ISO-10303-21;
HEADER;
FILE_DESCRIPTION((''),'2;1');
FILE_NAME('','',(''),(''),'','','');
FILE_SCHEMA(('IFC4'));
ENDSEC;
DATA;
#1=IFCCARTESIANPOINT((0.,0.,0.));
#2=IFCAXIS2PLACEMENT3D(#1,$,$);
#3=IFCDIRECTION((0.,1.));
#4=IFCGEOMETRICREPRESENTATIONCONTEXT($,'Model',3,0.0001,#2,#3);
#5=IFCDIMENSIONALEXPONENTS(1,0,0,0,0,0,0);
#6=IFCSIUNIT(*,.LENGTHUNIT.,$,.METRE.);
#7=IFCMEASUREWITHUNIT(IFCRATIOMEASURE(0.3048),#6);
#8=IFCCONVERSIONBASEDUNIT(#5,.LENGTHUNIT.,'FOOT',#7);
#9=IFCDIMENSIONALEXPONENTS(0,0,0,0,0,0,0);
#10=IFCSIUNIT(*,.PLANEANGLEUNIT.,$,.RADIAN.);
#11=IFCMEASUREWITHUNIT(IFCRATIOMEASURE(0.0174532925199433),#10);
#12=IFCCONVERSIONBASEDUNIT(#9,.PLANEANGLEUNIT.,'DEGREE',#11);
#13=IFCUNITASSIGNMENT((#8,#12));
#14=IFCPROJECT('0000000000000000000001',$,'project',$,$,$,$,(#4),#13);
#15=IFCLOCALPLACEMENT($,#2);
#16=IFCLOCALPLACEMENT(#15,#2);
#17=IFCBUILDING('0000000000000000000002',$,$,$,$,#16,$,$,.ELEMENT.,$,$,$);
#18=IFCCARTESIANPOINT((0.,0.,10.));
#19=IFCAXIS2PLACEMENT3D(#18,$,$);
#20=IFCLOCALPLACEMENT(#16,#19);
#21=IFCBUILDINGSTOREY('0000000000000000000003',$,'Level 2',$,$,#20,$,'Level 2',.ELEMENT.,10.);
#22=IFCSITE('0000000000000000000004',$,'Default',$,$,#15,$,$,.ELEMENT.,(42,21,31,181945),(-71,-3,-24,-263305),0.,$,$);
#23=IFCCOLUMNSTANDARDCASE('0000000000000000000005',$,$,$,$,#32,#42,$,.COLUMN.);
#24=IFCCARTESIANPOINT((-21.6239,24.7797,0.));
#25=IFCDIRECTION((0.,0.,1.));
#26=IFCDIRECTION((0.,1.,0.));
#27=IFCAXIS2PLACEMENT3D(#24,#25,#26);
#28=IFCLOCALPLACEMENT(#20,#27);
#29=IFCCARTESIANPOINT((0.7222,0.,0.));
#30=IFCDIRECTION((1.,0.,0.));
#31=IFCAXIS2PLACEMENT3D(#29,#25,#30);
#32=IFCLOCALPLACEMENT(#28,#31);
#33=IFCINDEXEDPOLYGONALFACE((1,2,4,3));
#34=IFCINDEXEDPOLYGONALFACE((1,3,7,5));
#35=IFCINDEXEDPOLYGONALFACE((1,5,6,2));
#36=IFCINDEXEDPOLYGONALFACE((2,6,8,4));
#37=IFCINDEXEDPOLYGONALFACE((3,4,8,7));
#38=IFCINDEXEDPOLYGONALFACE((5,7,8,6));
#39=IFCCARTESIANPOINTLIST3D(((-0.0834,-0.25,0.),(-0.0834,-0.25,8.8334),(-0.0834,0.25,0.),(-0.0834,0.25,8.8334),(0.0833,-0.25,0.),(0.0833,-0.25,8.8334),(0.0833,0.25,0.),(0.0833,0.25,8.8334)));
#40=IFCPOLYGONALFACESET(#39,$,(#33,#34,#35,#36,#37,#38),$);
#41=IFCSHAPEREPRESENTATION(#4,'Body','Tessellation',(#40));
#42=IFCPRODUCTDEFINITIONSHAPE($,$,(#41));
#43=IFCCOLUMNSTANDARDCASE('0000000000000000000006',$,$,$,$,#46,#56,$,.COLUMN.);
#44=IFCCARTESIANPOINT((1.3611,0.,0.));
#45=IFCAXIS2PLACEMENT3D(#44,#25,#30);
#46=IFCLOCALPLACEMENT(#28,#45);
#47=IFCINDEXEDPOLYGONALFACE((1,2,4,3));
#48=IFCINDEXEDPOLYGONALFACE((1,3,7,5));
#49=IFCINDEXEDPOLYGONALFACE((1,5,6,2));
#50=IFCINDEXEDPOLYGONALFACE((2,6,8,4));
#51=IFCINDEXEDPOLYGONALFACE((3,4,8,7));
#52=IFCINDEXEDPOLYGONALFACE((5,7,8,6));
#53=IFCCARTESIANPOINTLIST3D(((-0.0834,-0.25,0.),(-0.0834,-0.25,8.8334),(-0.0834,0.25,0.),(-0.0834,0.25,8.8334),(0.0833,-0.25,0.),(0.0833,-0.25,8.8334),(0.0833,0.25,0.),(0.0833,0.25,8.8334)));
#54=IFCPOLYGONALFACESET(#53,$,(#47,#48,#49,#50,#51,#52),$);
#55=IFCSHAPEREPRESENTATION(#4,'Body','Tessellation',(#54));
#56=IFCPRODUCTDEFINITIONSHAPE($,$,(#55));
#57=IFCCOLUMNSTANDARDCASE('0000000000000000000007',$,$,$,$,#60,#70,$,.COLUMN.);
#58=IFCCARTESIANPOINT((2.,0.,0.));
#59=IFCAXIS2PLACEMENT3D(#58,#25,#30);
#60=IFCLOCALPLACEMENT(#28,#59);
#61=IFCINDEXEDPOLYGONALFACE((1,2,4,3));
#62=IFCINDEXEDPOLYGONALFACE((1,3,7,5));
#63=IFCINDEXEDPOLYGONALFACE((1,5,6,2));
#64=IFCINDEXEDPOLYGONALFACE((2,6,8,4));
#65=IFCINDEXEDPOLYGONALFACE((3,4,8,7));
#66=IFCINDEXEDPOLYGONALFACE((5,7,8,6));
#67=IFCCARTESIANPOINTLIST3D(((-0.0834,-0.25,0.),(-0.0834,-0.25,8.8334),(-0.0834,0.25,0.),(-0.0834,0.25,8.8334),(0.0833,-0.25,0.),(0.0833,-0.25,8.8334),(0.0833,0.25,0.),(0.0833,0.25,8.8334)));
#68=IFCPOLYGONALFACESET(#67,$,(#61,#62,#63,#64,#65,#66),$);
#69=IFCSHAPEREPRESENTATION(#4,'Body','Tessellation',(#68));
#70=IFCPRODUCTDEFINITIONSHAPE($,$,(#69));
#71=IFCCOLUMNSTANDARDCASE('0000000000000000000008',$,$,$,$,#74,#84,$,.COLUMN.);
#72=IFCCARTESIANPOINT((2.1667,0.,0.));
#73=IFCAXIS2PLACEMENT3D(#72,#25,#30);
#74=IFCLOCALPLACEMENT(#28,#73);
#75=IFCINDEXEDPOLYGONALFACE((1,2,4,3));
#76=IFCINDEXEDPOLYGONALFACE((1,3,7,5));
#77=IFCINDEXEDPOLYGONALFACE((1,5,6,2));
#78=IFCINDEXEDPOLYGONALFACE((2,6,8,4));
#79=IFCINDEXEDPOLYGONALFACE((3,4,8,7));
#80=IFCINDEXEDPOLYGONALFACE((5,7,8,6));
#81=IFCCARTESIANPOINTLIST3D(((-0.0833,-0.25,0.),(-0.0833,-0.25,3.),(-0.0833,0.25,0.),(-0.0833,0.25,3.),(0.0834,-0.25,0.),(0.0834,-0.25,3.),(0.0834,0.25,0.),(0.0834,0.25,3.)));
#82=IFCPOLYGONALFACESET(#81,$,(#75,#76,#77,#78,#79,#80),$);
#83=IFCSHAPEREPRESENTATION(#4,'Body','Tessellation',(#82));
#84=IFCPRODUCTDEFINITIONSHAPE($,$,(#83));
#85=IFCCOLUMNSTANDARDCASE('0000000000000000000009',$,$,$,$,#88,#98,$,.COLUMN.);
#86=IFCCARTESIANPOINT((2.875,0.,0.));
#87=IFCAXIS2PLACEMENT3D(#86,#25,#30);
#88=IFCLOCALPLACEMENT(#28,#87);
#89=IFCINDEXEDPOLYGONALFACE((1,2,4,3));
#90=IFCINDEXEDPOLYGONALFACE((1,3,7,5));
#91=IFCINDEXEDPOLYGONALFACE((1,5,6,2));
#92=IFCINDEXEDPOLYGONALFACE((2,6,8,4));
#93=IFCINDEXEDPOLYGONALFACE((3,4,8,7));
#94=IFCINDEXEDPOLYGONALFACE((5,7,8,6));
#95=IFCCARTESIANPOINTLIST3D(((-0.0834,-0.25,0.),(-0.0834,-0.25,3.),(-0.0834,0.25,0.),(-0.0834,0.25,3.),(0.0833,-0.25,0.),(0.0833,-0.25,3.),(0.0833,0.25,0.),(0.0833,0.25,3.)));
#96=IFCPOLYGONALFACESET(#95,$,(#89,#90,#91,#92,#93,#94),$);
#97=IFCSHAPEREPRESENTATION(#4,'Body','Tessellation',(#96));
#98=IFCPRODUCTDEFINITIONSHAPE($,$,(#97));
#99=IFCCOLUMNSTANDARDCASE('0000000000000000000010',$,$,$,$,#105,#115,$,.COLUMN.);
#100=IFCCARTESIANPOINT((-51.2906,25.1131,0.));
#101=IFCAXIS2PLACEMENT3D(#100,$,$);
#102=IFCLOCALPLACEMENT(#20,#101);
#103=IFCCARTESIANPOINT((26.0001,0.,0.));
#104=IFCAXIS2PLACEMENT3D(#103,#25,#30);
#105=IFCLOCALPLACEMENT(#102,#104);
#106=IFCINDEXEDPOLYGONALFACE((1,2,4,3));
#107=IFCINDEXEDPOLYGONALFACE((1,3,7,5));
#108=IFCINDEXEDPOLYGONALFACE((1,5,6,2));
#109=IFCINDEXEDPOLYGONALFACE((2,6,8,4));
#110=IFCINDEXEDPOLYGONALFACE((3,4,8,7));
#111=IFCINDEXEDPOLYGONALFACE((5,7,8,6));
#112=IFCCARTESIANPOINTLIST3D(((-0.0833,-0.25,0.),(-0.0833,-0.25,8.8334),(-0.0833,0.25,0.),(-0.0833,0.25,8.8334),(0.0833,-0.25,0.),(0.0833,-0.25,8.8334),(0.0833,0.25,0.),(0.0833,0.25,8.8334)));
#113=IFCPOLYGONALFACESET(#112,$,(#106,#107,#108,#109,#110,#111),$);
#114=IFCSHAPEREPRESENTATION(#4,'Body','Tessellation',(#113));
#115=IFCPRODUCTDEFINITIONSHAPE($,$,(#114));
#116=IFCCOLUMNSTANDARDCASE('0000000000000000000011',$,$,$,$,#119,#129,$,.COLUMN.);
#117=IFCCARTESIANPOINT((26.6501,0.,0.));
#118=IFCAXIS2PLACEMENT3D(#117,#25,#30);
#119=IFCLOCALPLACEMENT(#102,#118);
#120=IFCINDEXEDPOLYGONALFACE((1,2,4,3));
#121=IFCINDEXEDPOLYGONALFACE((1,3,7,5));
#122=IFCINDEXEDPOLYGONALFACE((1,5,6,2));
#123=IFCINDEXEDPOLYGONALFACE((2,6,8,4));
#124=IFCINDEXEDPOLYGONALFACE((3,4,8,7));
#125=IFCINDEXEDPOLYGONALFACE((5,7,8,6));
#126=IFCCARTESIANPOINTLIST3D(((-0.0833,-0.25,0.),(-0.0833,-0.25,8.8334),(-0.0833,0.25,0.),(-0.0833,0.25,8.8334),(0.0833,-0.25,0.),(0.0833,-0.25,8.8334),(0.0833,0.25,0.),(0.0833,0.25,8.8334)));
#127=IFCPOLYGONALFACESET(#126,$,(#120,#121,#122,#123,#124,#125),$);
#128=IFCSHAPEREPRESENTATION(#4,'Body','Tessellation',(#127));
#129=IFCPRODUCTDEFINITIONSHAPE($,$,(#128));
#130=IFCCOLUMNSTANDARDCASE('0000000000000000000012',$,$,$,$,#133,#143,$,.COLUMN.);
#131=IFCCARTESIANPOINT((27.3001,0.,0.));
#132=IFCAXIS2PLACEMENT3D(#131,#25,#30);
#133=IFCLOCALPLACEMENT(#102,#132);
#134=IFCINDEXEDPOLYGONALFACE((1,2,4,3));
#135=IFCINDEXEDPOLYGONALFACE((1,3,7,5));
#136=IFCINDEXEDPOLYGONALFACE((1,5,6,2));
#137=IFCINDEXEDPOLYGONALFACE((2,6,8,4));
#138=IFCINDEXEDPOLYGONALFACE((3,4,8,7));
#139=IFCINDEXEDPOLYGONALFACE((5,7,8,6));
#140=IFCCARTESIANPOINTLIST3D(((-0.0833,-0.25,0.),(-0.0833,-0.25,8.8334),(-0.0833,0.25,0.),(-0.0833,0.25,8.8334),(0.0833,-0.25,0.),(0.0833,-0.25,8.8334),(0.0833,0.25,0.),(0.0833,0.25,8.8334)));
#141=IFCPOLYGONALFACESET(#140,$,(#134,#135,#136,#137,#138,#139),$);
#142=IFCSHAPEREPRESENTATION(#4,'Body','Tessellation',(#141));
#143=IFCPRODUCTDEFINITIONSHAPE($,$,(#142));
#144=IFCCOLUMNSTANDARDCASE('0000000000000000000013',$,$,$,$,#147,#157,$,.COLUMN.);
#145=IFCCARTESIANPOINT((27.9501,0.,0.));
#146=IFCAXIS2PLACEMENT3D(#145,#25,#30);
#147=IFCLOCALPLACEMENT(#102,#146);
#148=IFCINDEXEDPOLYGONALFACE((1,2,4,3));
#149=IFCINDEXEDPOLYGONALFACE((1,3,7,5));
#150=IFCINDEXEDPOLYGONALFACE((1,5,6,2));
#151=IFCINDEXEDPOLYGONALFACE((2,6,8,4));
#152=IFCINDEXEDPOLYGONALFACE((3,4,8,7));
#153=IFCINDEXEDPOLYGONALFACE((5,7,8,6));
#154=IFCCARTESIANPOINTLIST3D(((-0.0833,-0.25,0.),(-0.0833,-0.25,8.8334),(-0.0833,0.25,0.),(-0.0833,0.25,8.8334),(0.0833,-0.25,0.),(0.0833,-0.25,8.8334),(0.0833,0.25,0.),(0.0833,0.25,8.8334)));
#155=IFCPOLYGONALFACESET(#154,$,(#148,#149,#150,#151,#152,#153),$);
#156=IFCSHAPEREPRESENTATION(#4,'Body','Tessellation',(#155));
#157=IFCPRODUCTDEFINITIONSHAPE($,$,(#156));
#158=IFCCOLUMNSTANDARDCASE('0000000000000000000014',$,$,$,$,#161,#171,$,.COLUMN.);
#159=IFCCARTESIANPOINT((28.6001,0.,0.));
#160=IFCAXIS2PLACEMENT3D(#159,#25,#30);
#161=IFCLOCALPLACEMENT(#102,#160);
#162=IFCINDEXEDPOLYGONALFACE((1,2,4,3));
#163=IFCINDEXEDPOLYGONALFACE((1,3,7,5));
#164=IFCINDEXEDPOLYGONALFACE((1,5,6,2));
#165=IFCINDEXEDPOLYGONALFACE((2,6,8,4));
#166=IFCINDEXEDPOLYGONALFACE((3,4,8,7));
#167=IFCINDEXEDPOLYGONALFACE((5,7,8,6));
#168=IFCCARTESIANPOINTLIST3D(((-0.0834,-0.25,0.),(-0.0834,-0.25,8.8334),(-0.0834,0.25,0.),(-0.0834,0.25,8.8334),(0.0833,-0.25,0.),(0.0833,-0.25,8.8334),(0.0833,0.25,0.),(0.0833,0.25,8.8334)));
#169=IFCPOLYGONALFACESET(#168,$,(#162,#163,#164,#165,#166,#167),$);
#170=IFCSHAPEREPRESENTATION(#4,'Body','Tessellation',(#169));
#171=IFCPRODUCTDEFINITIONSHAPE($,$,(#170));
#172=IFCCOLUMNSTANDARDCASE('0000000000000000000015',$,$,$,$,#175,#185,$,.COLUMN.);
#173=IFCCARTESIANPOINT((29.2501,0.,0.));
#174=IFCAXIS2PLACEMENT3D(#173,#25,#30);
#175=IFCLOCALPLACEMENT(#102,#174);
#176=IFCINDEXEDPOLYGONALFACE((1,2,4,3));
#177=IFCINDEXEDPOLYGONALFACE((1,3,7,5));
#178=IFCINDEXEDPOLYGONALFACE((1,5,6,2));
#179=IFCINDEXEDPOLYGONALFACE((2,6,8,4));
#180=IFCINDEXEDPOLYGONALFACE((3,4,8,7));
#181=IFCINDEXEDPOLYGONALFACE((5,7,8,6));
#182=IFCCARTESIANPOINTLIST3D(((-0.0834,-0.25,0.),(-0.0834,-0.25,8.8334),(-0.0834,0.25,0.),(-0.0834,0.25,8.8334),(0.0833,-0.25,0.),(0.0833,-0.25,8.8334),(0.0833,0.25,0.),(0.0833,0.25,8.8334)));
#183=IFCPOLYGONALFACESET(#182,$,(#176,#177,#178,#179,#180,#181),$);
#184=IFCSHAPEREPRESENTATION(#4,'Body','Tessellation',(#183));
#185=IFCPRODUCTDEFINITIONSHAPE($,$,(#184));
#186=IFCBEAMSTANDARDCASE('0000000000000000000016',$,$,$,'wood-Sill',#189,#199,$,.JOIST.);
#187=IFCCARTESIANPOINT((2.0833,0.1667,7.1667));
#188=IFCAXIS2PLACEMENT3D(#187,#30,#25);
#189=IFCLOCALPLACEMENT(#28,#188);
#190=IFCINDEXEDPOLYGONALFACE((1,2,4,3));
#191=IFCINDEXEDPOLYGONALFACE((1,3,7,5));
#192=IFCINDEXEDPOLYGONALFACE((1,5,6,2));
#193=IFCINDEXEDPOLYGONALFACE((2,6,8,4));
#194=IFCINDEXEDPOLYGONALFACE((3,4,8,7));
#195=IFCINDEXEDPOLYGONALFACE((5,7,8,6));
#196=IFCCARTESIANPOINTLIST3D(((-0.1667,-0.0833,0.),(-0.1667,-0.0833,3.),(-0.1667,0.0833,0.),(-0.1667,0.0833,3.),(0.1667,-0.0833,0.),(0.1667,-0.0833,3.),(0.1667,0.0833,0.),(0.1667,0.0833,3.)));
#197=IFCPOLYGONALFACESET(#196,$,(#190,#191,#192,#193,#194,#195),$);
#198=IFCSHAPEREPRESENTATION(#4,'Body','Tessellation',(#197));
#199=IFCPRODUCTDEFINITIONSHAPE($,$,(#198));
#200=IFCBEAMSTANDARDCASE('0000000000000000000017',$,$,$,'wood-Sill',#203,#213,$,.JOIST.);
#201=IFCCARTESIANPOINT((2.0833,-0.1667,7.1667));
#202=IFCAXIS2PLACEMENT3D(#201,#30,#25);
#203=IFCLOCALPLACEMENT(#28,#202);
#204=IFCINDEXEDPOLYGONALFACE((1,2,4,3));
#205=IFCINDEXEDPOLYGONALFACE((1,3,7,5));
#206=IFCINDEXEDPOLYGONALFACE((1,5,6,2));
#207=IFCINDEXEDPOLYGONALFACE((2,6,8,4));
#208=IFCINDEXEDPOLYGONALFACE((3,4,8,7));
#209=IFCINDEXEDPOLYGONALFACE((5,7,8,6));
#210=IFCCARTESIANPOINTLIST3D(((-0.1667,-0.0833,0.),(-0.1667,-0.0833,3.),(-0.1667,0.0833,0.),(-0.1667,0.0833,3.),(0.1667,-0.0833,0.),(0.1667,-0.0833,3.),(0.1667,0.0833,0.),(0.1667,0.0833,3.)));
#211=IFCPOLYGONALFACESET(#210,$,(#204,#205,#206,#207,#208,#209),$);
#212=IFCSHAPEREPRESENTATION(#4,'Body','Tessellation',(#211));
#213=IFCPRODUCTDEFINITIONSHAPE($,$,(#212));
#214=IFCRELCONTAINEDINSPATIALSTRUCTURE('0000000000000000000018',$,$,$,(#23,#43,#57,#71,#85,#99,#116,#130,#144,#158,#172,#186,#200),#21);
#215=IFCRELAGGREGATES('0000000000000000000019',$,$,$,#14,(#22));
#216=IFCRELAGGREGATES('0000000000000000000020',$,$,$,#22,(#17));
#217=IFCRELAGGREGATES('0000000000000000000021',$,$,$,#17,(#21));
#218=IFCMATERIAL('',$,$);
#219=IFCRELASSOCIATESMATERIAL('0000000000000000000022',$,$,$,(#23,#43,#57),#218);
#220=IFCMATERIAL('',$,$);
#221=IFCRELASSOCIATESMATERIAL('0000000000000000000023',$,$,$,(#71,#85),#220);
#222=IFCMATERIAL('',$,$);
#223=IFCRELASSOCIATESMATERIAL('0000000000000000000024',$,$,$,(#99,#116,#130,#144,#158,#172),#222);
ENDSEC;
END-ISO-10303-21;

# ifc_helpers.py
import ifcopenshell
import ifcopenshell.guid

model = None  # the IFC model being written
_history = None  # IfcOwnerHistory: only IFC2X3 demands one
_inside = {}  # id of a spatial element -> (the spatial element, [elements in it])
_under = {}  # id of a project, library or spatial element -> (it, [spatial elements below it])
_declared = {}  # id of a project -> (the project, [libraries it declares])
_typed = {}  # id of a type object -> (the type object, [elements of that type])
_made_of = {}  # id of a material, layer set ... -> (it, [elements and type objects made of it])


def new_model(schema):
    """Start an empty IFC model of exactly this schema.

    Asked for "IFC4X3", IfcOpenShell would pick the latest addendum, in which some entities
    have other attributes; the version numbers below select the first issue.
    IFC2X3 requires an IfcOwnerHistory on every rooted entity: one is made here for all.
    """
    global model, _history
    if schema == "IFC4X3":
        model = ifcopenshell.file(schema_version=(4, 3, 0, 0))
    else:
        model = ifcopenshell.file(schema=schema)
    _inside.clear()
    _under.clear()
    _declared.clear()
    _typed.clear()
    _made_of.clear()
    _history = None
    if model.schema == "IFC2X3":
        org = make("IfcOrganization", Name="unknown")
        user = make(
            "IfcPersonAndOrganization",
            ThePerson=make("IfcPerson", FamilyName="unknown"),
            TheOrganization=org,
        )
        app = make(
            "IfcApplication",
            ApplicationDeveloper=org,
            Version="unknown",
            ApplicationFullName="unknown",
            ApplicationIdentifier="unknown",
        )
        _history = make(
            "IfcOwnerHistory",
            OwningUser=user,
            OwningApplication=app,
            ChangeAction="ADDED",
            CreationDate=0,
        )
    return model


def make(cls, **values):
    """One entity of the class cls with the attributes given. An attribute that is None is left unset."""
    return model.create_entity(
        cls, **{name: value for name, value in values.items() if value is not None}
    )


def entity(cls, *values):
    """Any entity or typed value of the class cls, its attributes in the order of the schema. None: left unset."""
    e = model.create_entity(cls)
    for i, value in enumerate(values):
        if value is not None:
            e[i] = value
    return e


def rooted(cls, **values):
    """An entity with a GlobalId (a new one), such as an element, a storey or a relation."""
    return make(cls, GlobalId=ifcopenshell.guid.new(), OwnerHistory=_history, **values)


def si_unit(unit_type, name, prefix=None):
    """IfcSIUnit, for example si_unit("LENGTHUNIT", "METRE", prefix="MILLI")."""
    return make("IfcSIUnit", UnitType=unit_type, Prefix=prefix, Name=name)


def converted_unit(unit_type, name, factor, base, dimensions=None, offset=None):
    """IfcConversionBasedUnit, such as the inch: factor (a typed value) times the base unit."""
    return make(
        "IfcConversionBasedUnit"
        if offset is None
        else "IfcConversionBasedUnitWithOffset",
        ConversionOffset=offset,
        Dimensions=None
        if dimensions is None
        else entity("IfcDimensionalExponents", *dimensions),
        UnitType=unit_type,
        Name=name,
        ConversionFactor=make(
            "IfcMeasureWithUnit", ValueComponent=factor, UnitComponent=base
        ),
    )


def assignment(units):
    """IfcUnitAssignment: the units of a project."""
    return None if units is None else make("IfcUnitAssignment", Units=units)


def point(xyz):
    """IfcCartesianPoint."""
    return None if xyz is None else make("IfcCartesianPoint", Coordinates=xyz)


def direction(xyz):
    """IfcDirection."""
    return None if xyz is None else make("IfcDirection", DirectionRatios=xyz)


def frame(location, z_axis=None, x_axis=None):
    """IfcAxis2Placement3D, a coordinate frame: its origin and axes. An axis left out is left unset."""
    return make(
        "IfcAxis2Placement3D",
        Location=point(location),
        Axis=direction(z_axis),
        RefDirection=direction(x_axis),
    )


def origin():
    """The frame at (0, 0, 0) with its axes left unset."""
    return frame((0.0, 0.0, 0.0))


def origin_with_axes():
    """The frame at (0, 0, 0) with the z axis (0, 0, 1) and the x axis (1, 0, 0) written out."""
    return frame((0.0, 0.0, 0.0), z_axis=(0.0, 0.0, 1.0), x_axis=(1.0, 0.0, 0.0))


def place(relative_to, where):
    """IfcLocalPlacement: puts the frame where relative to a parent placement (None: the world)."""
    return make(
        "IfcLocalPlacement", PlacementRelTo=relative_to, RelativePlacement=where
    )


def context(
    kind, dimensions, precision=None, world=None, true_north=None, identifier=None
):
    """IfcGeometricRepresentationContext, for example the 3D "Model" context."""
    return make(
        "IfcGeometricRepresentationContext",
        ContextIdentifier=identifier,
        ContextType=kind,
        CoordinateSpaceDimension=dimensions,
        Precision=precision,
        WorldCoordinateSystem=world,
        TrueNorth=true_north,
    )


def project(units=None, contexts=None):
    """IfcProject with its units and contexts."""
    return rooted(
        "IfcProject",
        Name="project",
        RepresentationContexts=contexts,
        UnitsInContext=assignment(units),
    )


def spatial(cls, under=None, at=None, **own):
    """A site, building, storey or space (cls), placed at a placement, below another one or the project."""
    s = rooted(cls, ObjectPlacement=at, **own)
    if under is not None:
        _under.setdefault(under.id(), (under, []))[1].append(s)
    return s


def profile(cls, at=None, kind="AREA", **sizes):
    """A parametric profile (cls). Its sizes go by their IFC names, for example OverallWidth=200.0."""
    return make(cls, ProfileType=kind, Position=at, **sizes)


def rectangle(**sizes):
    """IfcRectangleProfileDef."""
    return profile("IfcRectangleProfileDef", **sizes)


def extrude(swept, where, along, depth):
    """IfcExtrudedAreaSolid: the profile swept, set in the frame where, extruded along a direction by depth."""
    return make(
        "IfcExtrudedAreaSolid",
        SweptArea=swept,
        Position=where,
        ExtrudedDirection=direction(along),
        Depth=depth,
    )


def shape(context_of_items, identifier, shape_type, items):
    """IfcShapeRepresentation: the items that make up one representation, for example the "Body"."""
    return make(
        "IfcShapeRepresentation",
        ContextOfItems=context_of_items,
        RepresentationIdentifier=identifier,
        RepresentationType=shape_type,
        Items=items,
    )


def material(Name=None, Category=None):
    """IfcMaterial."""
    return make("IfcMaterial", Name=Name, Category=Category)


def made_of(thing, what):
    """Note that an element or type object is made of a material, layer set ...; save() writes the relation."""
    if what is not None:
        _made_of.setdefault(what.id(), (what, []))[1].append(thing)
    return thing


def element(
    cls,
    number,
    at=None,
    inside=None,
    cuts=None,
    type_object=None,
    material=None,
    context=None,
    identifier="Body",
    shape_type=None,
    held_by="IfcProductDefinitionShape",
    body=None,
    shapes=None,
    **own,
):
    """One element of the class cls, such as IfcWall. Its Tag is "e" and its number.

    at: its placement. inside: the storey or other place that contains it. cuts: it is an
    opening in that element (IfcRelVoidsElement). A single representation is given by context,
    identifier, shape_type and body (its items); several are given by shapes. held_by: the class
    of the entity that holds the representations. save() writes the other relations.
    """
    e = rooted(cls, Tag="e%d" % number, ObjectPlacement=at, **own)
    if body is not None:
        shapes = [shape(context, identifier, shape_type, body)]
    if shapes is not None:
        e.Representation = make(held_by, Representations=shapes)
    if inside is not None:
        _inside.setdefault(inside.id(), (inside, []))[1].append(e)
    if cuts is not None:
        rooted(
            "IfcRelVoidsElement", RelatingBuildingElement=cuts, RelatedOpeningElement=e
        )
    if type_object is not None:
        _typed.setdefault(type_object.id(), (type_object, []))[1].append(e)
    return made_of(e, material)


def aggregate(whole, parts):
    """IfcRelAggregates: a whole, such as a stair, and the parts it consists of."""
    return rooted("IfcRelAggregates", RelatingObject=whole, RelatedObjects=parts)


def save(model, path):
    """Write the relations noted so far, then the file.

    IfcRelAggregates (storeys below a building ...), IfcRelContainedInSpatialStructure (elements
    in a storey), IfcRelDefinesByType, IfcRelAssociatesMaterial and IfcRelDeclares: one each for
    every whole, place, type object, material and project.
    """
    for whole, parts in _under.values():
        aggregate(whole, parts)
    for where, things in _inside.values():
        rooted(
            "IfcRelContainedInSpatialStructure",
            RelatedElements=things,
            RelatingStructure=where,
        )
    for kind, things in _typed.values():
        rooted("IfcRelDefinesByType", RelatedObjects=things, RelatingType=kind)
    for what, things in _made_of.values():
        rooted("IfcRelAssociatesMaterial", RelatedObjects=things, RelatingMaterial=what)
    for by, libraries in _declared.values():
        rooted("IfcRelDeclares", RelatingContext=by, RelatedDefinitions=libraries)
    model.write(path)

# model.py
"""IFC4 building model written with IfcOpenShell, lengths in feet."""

from ifc_helpers import new_model, entity, si_unit, converted_unit, direction, frame, origin, origin_with_axes, place, context, project, spatial, rectangle, extrude, material, element, save


model = new_model("IFC4")

# Units and contexts
model_context = context("Model", 3, precision=0.0001, world=origin(), true_north=direction((0.0, 1.0)))
ifc_project = project(units=[converted_unit("LENGTHUNIT", "FOOT", entity("IfcRatioMeasure", 0.3048), si_unit("LENGTHUNIT", "METRE"), dimensions=[1, 0, 0, 0, 0, 0, 0]), converted_unit("PLANEANGLEUNIT", "DEGREE", entity("IfcRatioMeasure", 0.0174532925199433), si_unit("PLANEANGLEUNIT", "RADIAN"), dimensions=[0, 0, 0, 0, 0, 0, 0])], contexts=[model_context])

# Site, building, storey
site_placement = place(None, origin())
site = spatial("IfcSite", under=ifc_project, at=site_placement, Name="Default", CompositionType="ELEMENT", RefLatitude=(42, 21, 31, 181945), RefLongitude=(-71, -3, -24, -263305), RefElevation=0.0)
building_placement = place(site_placement, origin())
building = spatial("IfcBuilding", under=site, at=building_placement, CompositionType="ELEMENT")
storey_placement = place(building_placement, frame((0.0, 0.0, 10.0)))
storey = spatial("IfcBuildingStorey", under=building, at=storey_placement, Name="Level 2", LongName="Level 2", CompositionType="ELEMENT", Elevation=10.0)

# Columns
ifc_material_1 = material(Name="")
placement_1 = place(storey_placement, frame((-21.6239, 24.7797, 0.0), z_axis=(0.0, 0.0, 1.0), x_axis=(0.0, 1.0, 0.0)))
for number, where, z_axis, x_axis in (
    (1, (0.7222, 0.0, 0.0), (0.0, 0.0, 1.0), (1.0, 0.0, 0.0)),
    (2, (1.3611, 0.0, 0.0), (0.0, 0.0, 1.0), (1.0, 0.0, 0.0)),
    (3, (2.0, 0.0, 0.0), (0.0, 0.0, 1.0), (1.0, 0.0, 0.0)),
):
    element("IfcColumnStandardCase", number, at=place(placement_1, frame(where, z_axis=z_axis, x_axis=x_axis)), inside=storey, material=ifc_material_1, PredefinedType="COLUMN", context=model_context, shape_type="SweptSolid", body=[
        extrude(rectangle(XDim=0.1667, YDim=0.5), origin(), (0.0, 0.0, 1.0), 8.8334),
    ])
ifc_material_2 = material(Name="")
for number, where, z_axis, x_axis in (
    (4, (2.1667, 0.0, 0.0), (0.0, 0.0, 1.0), (1.0, 0.0, 0.0)),
    (5, (2.875, 0.0, 0.0), (0.0, 0.0, 1.0), (1.0, 0.0, 0.0)),
):
    element("IfcColumnStandardCase", number, at=place(placement_1, frame(where, z_axis=z_axis, x_axis=x_axis)), inside=storey, material=ifc_material_2, PredefinedType="COLUMN", context=model_context, shape_type="SweptSolid", body=[
        extrude(rectangle(XDim=0.1667, YDim=0.5), origin(), (0.0, 0.0, 1.0), 3.0),
    ])
ifc_material_3 = material(Name="")
placement_2 = place(storey_placement, frame((-51.2906, 25.1131, 0.0)))
for number, where, z_axis, x_axis in (
    (6, (26.0001, 0.0, 0.0), (0.0, 0.0, 1.0), (1.0, 0.0, 0.0)),
    (7, (26.6501, 0.0, 0.0), (0.0, 0.0, 1.0), (1.0, 0.0, 0.0)),
    (8, (27.3001, 0.0, 0.0), (0.0, 0.0, 1.0), (1.0, 0.0, 0.0)),
    (9, (27.9501, 0.0, 0.0), (0.0, 0.0, 1.0), (1.0, 0.0, 0.0)),
    (10, (28.6001, 0.0, 0.0), (0.0, 0.0, 1.0), (1.0, 0.0, 0.0)),
    (11, (29.2501, 0.0, 0.0), (0.0, 0.0, 1.0), (1.0, 0.0, 0.0)),
):
    element("IfcColumnStandardCase", number, at=place(placement_2, frame(where, z_axis=z_axis, x_axis=x_axis)), inside=storey, material=ifc_material_3, PredefinedType="COLUMN", context=model_context, shape_type="SweptSolid", body=[
        extrude(rectangle(XDim=0.1667, YDim=0.5), origin(), (0.0, 0.0, 1.0), 8.8334),
    ])

# Beams
for number, where, z_axis, x_axis in (
    (12, (2.0833, 0.1667, 7.1667), (1.0, 0.0, 0.0), (0.0, 0.0, 1.0)),
    (13, (2.0833, -0.1667, 7.1667), (1.0, 0.0, 0.0), (0.0, 0.0, 1.0)),
):
    element("IfcBeamStandardCase", number, at=place(placement_1, frame(where, z_axis=z_axis, x_axis=x_axis)), inside=storey, ObjectType="wood-Sill", PredefinedType="JOIST", context=model_context, shape_type="SweptSolid", body=[
        extrude(rectangle(XDim=0.3333, YDim=0.1667), origin_with_axes(), (0.0, 0.0, 1.0), 3.0),
    ])

save(model, "model.ifc")
